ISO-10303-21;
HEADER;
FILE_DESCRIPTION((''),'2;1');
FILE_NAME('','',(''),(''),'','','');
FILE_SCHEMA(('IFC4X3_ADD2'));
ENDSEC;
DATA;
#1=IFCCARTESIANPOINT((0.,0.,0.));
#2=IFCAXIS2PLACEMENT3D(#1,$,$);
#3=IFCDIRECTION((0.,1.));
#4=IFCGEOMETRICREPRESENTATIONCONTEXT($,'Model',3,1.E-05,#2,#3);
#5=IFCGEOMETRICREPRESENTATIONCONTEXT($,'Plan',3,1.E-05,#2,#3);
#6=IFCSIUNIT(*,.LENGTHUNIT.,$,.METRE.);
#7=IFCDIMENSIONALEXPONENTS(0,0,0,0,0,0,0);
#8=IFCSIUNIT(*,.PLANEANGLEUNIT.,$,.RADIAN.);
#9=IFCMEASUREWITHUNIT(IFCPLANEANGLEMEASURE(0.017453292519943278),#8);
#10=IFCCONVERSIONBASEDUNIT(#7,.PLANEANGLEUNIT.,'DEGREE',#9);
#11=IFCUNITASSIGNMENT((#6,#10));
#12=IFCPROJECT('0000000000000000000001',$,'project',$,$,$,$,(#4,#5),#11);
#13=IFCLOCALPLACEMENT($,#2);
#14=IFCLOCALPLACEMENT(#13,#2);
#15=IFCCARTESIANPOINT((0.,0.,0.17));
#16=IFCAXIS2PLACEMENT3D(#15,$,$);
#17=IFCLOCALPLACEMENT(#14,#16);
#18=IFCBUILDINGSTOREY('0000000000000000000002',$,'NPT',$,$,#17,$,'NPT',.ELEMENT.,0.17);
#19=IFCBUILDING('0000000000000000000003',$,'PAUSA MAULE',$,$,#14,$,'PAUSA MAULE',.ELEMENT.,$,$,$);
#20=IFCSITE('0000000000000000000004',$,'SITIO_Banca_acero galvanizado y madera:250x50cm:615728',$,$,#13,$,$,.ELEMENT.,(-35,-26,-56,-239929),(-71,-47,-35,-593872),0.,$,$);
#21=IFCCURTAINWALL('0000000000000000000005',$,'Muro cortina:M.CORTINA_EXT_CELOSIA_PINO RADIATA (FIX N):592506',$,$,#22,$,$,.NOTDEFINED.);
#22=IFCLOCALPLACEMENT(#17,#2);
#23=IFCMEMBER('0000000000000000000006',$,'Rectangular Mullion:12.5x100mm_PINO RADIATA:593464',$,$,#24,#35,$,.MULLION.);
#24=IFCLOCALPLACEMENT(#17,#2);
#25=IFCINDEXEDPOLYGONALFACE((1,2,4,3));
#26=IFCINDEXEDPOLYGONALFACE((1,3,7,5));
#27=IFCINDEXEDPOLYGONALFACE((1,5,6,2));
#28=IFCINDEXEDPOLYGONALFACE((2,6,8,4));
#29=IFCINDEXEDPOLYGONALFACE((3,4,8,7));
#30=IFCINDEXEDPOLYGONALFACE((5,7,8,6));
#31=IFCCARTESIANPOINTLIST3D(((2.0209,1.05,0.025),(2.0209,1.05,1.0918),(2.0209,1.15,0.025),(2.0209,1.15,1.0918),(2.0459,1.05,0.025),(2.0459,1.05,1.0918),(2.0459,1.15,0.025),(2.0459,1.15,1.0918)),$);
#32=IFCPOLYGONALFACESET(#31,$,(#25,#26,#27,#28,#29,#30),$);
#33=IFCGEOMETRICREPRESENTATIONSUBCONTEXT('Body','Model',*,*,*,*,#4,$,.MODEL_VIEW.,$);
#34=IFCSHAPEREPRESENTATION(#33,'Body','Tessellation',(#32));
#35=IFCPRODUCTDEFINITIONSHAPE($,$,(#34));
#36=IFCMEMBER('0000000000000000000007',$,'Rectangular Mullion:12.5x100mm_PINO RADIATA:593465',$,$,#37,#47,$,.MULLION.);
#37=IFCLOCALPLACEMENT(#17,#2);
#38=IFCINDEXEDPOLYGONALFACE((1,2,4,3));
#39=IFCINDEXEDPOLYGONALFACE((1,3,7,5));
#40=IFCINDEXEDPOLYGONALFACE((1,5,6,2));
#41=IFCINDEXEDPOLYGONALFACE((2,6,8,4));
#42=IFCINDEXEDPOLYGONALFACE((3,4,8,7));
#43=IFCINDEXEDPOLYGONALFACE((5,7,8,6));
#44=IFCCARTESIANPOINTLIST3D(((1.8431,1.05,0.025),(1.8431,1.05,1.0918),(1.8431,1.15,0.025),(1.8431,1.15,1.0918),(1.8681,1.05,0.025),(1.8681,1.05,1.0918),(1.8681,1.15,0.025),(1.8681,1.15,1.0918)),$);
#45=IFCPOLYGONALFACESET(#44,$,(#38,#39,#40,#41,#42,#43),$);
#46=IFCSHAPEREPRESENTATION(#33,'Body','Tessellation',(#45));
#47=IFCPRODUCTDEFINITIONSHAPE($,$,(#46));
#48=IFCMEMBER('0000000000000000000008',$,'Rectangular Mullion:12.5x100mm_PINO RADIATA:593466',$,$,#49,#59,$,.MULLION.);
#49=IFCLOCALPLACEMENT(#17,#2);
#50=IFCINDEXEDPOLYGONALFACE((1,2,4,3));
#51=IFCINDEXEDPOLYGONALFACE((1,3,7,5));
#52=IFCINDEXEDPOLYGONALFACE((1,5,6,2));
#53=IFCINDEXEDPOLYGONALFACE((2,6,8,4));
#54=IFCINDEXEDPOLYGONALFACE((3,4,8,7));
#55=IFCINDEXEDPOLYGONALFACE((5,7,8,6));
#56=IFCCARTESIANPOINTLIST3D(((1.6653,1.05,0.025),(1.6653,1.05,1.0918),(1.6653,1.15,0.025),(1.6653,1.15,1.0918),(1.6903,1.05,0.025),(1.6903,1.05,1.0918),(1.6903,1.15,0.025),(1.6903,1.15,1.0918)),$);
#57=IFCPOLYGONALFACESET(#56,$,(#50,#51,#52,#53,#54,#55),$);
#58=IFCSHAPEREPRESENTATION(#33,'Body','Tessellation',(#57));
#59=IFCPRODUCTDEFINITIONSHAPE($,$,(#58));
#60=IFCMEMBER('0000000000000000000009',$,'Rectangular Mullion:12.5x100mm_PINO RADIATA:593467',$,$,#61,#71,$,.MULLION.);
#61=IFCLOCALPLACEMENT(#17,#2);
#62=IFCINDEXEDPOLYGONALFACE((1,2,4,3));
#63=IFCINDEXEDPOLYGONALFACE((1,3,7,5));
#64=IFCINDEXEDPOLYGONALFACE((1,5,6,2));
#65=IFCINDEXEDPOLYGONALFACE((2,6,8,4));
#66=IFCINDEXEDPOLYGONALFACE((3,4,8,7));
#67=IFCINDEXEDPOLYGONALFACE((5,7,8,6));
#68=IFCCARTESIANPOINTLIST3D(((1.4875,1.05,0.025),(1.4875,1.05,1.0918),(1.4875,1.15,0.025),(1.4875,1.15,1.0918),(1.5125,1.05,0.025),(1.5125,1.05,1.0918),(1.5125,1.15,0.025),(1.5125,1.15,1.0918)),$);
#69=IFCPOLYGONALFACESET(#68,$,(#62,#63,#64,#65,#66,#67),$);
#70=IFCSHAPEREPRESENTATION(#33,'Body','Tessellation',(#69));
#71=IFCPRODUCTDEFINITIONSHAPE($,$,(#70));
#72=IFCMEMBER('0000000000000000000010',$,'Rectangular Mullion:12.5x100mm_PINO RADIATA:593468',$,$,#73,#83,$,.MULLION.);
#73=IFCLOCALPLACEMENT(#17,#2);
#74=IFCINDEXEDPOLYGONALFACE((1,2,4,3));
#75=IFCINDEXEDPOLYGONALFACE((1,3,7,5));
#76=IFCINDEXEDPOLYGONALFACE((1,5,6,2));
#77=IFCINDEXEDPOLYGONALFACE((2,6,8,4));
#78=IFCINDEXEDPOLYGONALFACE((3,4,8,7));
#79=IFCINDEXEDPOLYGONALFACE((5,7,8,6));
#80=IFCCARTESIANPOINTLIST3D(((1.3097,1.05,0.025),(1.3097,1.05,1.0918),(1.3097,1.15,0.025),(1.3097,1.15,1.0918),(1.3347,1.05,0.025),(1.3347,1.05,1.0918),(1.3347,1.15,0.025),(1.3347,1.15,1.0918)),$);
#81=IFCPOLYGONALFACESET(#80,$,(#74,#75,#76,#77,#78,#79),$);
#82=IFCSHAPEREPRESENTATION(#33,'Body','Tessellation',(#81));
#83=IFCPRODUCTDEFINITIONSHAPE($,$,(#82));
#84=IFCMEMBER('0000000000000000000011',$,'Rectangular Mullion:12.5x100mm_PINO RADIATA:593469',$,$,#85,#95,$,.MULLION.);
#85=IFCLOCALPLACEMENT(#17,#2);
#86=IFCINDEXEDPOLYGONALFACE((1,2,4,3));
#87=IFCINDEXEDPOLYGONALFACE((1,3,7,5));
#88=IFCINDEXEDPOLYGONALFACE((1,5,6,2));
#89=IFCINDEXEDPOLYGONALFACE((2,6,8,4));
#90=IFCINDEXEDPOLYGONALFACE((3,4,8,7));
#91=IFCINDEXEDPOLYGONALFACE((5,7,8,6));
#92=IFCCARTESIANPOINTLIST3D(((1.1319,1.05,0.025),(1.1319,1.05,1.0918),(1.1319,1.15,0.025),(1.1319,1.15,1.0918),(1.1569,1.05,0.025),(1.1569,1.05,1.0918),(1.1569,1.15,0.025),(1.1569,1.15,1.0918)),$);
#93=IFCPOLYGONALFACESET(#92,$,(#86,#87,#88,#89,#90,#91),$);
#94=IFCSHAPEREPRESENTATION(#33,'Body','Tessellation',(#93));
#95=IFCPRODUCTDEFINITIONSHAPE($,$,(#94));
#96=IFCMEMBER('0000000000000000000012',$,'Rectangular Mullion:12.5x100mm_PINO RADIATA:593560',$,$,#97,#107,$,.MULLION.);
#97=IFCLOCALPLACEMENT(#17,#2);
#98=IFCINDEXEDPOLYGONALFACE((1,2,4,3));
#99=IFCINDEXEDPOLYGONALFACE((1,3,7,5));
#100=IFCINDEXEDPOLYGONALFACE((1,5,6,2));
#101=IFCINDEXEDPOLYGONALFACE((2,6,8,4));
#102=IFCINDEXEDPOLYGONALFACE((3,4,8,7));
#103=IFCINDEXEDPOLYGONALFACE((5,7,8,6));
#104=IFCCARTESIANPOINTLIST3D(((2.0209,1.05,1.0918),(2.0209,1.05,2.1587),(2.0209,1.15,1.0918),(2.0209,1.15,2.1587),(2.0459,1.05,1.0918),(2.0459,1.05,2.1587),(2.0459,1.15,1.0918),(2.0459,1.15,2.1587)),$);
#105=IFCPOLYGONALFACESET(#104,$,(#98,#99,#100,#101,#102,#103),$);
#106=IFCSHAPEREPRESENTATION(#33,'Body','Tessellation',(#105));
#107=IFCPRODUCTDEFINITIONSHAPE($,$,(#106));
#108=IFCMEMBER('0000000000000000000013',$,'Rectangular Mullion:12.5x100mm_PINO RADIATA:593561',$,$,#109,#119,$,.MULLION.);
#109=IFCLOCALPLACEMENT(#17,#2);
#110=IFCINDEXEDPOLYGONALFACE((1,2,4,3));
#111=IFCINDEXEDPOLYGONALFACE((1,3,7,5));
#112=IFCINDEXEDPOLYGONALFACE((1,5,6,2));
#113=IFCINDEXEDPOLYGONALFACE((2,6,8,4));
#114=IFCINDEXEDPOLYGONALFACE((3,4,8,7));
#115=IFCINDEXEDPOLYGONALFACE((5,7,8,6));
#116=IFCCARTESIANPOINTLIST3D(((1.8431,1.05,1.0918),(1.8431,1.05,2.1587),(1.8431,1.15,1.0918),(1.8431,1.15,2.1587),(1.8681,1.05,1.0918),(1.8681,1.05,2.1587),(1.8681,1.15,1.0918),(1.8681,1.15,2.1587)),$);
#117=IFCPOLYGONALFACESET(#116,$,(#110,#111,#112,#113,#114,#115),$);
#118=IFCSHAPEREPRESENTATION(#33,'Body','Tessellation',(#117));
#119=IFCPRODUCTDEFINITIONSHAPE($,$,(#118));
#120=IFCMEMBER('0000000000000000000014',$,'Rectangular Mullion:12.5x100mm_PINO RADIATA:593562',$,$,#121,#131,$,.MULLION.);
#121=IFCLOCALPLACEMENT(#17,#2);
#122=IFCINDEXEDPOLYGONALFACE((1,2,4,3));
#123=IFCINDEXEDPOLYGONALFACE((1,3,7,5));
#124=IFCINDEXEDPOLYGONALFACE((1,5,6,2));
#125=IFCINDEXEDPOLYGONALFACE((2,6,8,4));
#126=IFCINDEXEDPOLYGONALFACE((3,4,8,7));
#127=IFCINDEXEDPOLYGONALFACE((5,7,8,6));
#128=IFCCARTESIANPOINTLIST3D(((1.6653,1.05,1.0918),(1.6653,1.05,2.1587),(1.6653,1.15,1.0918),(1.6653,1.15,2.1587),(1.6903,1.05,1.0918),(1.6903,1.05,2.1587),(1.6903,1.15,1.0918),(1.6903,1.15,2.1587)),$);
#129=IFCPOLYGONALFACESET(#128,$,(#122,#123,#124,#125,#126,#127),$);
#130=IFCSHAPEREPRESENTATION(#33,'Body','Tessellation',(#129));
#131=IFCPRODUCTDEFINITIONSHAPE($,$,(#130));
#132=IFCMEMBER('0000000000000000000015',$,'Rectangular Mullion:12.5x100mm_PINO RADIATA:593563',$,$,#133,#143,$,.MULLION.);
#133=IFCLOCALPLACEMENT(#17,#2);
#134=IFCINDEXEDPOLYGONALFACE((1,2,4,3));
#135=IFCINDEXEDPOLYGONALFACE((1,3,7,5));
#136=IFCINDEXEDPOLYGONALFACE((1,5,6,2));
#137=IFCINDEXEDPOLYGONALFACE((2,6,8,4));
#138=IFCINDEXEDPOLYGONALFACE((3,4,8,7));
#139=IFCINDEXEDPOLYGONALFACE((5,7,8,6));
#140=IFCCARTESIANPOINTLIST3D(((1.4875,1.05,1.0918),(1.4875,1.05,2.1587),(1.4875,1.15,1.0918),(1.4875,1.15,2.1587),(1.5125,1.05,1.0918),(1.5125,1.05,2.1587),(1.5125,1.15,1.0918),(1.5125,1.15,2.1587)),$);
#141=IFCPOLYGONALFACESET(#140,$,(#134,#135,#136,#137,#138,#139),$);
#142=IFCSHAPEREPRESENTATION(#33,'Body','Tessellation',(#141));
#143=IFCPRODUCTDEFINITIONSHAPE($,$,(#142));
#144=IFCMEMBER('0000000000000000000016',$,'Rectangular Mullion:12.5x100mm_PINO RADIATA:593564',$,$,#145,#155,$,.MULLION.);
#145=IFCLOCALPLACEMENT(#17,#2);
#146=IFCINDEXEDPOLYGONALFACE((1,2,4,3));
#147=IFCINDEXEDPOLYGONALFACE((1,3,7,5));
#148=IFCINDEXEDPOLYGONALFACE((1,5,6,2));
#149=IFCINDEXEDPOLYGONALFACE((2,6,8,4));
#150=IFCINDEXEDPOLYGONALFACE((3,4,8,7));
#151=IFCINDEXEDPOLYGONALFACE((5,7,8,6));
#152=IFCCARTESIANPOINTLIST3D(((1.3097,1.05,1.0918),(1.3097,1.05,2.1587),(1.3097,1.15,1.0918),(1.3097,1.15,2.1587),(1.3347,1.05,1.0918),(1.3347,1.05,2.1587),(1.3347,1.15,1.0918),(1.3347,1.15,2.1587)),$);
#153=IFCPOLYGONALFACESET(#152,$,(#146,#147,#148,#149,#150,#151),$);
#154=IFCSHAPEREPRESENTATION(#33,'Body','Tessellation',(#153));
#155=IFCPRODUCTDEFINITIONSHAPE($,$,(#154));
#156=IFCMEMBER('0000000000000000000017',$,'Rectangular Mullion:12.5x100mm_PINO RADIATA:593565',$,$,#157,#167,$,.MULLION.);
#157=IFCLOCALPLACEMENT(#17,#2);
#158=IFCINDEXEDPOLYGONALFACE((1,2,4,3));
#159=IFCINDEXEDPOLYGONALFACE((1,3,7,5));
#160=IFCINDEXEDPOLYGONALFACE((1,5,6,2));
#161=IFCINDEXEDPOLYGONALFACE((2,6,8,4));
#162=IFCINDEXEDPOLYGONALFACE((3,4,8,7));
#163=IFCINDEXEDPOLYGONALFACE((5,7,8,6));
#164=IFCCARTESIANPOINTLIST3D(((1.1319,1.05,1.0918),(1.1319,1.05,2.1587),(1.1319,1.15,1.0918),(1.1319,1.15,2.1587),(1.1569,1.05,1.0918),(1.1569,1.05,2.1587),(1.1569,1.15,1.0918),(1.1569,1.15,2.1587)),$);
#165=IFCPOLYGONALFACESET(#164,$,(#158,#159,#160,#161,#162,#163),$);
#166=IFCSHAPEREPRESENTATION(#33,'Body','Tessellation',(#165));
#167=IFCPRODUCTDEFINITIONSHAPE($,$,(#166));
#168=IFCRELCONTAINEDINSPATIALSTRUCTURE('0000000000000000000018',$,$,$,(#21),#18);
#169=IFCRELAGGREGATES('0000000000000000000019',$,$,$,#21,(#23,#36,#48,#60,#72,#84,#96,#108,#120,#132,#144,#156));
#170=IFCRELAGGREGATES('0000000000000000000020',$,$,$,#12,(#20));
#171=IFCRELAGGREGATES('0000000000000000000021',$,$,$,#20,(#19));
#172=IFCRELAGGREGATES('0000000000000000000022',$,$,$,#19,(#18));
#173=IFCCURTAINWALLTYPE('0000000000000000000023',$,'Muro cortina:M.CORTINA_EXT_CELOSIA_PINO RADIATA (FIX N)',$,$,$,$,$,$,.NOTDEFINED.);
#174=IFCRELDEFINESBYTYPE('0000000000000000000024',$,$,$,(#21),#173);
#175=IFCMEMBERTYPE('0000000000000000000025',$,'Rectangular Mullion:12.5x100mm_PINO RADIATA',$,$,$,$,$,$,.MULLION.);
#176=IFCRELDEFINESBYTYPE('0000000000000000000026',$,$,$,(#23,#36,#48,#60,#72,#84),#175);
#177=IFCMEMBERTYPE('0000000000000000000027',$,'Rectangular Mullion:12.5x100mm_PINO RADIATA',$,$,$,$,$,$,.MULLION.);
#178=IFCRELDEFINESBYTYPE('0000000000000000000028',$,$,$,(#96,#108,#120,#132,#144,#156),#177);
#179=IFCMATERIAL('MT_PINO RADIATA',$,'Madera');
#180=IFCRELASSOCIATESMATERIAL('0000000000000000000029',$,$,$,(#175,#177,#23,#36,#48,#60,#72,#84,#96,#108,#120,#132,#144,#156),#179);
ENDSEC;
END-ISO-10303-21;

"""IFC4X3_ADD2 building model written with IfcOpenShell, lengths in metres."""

from ifc_helpers import new_model, entity, si_unit, converted_unit, direction, frame, frame_2d, origin, origin_2d_with_axis, place, context, subcontext, project, spatial, rectangle, extrude, source, transform, mapped, material, material_profile, profile_set, profile_usage, type_object, type_shapes, element, aggregate, save


model = new_model("IFC4X3_ADD2")

# Units and contexts
model_context = context("Model", 3, precision=1e-05, world=origin(), true_north=direction((0.0, 1.0)))
plan_context = context("Plan", 3, precision=1e-05, world=origin(), true_north=direction((0.0, 1.0)))
body_context = subcontext(model_context, "Body", "Model", "MODEL_VIEW")
ifc_project = project(units=[si_unit("LENGTHUNIT", "METRE"), converted_unit("PLANEANGLEUNIT", "DEGREE", entity("IfcPlaneAngleMeasure", 0.017453292519943278), si_unit("PLANEANGLEUNIT", "RADIAN"), dimensions=[0, 0, 0, 0, 0, 0, 0])], contexts=[model_context, plan_context])

# Site, building, storey
site_placement = place(None, origin())
site = spatial("IfcSite", under=ifc_project, at=site_placement, Name="SITIO_Banca_acero galvanizado y madera:250x50cm:615728", CompositionType="ELEMENT", RefLatitude=(-35, -26, -56, -239929), RefLongitude=(-71, -47, -35, -593872), RefElevation=0.0)
building_placement = place(site_placement, origin())
building = spatial("IfcBuilding", under=site, at=building_placement, Name="PAUSA MAULE", LongName="PAUSA MAULE", CompositionType="ELEMENT")
storey_placement = place(building_placement, frame((0.0, 0.0, 0.17)))
storey = spatial("IfcBuildingStorey", under=building, at=storey_placement, Name="NPT", LongName="NPT", CompositionType="ELEMENT", Elevation=0.17)

# Curtain wall, members
curtain_wall_type = type_object("IfcCurtainWallType", Name="Muro cortina:M.CORTINA_EXT_CELOSIA_PINO RADIATA (FIX N)", PredefinedType="NOTDEFINED")
curtain_wall_placement = place(storey_placement, frame((0.0, 0.0, -0.17)))
curtain_wall = element("IfcCurtainWall", 1, at=curtain_wall_placement, inside=storey, type_object=curtain_wall_type, Name="Muro cortina:M.CORTINA_EXT_CELOSIA_PINO RADIATA (FIX N):592506", PredefinedType="NOTDEFINED")
ifc_material = material(Name="MT_PINO RADIATA", Category="Madera")
ifc_material_profile = material_profile(ifc_material, rectangle(XDim=0.025, YDim=0.1, at=frame_2d((0.0, 0.0), x_axis=(1.0, 0.0))), Name="12.5x100mm_PINO RADIATA")
ifc_profile_set = profile_set([ifc_material_profile], Name="12.5x100mm_PINO RADIATA")
ifc_profile_usage = profile_usage(ifc_profile_set)
member_type_1 = type_object("IfcMemberType", Name="Rectangular Mullion:12.5x100mm_PINO RADIATA", PredefinedType="MULLION", material=ifc_profile_set)
shared_shape_1 = source(origin(), body_context, "Body", "SweptSolid", [
    extrude(rectangle(XDim=0.025, YDim=0.1, at=origin_2d_with_axis()), frame((0.0, 0.0, -1.0668), z_axis=(0.0, 0.0, 1.0), x_axis=(-1.0, 0.0, 0.0)), (0.0, 0.0, 1.0), 1.0668),
])
type_shapes(member_type_1, [shared_shape_1])
member_1_placement = place(curtain_wall_placement, frame((2.0334, 1.1, 0.195), z_axis=(0.0, 0.0, -1.0), x_axis=(-1.0, 0.0, 0.0)))
member_1 = element("IfcMember", 2, at=member_1_placement, type_object=member_type_1, material=ifc_profile_usage, Name="Rectangular Mullion:12.5x100mm_PINO RADIATA:593464", PredefinedType="MULLION", context=body_context, shape_type="MappedRepresentation", body=[
    mapped(shared_shape_1, transform((0.0, 0.0, 0.0), scale=1.0)),
])
member_2_placement = place(curtain_wall_placement, frame((1.8556, 1.1, 0.195), z_axis=(0.0, 0.0, -1.0), x_axis=(-1.0, 0.0, 0.0)))
member_2 = element("IfcMember", 3, at=member_2_placement, type_object=member_type_1, material=ifc_profile_usage, Name="Rectangular Mullion:12.5x100mm_PINO RADIATA:593465", PredefinedType="MULLION", context=body_context, shape_type="MappedRepresentation", body=[
    mapped(shared_shape_1, transform((0.0, 0.0, 0.0), scale=1.0)),
])
member_3_placement = place(curtain_wall_placement, frame((1.6778, 1.1, 0.195), z_axis=(0.0, 0.0, -1.0), x_axis=(-1.0, 0.0, 0.0)))
member_3 = element("IfcMember", 4, at=member_3_placement, type_object=member_type_1, material=ifc_profile_usage, Name="Rectangular Mullion:12.5x100mm_PINO RADIATA:593466", PredefinedType="MULLION", context=body_context, shape_type="MappedRepresentation", body=[
    mapped(shared_shape_1, transform((0.0, 0.0, 0.0), scale=1.0)),
])
member_4_placement = place(curtain_wall_placement, frame((1.5, 1.1, 0.195), z_axis=(0.0, 0.0, -1.0), x_axis=(-1.0, 0.0, 0.0)))
member_4 = element("IfcMember", 5, at=member_4_placement, type_object=member_type_1, material=ifc_profile_usage, Name="Rectangular Mullion:12.5x100mm_PINO RADIATA:593467", PredefinedType="MULLION", context=body_context, shape_type="MappedRepresentation", body=[
    mapped(shared_shape_1, transform((0.0, 0.0, 0.0), scale=1.0)),
])
member_5_placement = place(curtain_wall_placement, frame((1.3222, 1.1, 0.195), z_axis=(0.0, 0.0, -1.0), x_axis=(-1.0, 0.0, 0.0)))
member_5 = element("IfcMember", 6, at=member_5_placement, type_object=member_type_1, material=ifc_profile_usage, Name="Rectangular Mullion:12.5x100mm_PINO RADIATA:593468", PredefinedType="MULLION", context=body_context, shape_type="MappedRepresentation", body=[
    mapped(shared_shape_1, transform((0.0, 0.0, 0.0), scale=1.0)),
])
member_6_placement = place(curtain_wall_placement, frame((1.1444, 1.1, 0.195), z_axis=(0.0, 0.0, -1.0), x_axis=(-1.0, 0.0, 0.0)))
member_6 = element("IfcMember", 7, at=member_6_placement, type_object=member_type_1, material=ifc_profile_usage, Name="Rectangular Mullion:12.5x100mm_PINO RADIATA:593469", PredefinedType="MULLION", context=body_context, shape_type="MappedRepresentation", body=[
    mapped(shared_shape_1, transform((0.0, 0.0, 0.0), scale=1.0)),
])
member_type_2 = type_object("IfcMemberType", Name="Rectangular Mullion:12.5x100mm_PINO RADIATA", PredefinedType="MULLION", material=ifc_profile_set)
shared_shape_2 = source(origin(), body_context, "Body", "SweptSolid", [
    extrude(rectangle(XDim=0.025, YDim=0.1, at=origin_2d_with_axis()), frame((0.0, 0.0, -1.0668), z_axis=(0.0, 0.0, 1.0), x_axis=(-1.0, 0.0, 0.0)), (0.0, 0.0, 1.0), 1.0668),
])
type_shapes(member_type_2, [shared_shape_2])
member_7_placement = place(curtain_wall_placement, frame((2.0334, 1.1, 1.2618), z_axis=(0.0, 0.0, -1.0), x_axis=(-1.0, 0.0, 0.0)))
member_7 = element("IfcMember", 8, at=member_7_placement, type_object=member_type_2, material=ifc_profile_usage, Name="Rectangular Mullion:12.5x100mm_PINO RADIATA:593560", PredefinedType="MULLION", context=body_context, shape_type="MappedRepresentation", body=[
    mapped(shared_shape_2, transform((0.0, 0.0, 0.0), scale=1.0)),
])
member_8_placement = place(curtain_wall_placement, frame((1.8556, 1.1, 1.2618), z_axis=(0.0, 0.0, -1.0), x_axis=(-1.0, 0.0, 0.0)))
member_8 = element("IfcMember", 9, at=member_8_placement, type_object=member_type_2, material=ifc_profile_usage, Name="Rectangular Mullion:12.5x100mm_PINO RADIATA:593561", PredefinedType="MULLION", context=body_context, shape_type="MappedRepresentation", body=[
    mapped(shared_shape_2, transform((0.0, 0.0, 0.0), scale=1.0)),
])
member_9_placement = place(curtain_wall_placement, frame((1.6778, 1.1, 1.2618), z_axis=(0.0, 0.0, -1.0), x_axis=(-1.0, 0.0, 0.0)))
member_9 = element("IfcMember", 10, at=member_9_placement, type_object=member_type_2, material=ifc_profile_usage, Name="Rectangular Mullion:12.5x100mm_PINO RADIATA:593562", PredefinedType="MULLION", context=body_context, shape_type="MappedRepresentation", body=[
    mapped(shared_shape_2, transform((0.0, 0.0, 0.0), scale=1.0)),
])
member_10_placement = place(curtain_wall_placement, frame((1.5, 1.1, 1.2618), z_axis=(0.0, 0.0, -1.0), x_axis=(-1.0, 0.0, 0.0)))
member_10 = element("IfcMember", 11, at=member_10_placement, type_object=member_type_2, material=ifc_profile_usage, Name="Rectangular Mullion:12.5x100mm_PINO RADIATA:593563", PredefinedType="MULLION", context=body_context, shape_type="MappedRepresentation", body=[
    mapped(shared_shape_2, transform((0.0, 0.0, 0.0), scale=1.0)),
])
member_11_placement = place(curtain_wall_placement, frame((1.3222, 1.1, 1.2618), z_axis=(0.0, 0.0, -1.0), x_axis=(-1.0, 0.0, 0.0)))
member_11 = element("IfcMember", 12, at=member_11_placement, type_object=member_type_2, material=ifc_profile_usage, Name="Rectangular Mullion:12.5x100mm_PINO RADIATA:593564", PredefinedType="MULLION", context=body_context, shape_type="MappedRepresentation", body=[
    mapped(shared_shape_2, transform((0.0, 0.0, 0.0), scale=1.0)),
])
member_12_placement = place(curtain_wall_placement, frame((1.1444, 1.1, 1.2618), z_axis=(0.0, 0.0, -1.0), x_axis=(-1.0, 0.0, 0.0)))
member_12 = element("IfcMember", 13, at=member_12_placement, type_object=member_type_2, material=ifc_profile_usage, Name="Rectangular Mullion:12.5x100mm_PINO RADIATA:593565", PredefinedType="MULLION", context=body_context, shape_type="MappedRepresentation", body=[
    mapped(shared_shape_2, transform((0.0, 0.0, 0.0), scale=1.0)),
])
aggregate(curtain_wall, [member_1, member_2, member_3, member_4, member_5, member_6, member_7, member_8, member_9, member_10, member_11, member_12])

save(model, "model.ifc")
